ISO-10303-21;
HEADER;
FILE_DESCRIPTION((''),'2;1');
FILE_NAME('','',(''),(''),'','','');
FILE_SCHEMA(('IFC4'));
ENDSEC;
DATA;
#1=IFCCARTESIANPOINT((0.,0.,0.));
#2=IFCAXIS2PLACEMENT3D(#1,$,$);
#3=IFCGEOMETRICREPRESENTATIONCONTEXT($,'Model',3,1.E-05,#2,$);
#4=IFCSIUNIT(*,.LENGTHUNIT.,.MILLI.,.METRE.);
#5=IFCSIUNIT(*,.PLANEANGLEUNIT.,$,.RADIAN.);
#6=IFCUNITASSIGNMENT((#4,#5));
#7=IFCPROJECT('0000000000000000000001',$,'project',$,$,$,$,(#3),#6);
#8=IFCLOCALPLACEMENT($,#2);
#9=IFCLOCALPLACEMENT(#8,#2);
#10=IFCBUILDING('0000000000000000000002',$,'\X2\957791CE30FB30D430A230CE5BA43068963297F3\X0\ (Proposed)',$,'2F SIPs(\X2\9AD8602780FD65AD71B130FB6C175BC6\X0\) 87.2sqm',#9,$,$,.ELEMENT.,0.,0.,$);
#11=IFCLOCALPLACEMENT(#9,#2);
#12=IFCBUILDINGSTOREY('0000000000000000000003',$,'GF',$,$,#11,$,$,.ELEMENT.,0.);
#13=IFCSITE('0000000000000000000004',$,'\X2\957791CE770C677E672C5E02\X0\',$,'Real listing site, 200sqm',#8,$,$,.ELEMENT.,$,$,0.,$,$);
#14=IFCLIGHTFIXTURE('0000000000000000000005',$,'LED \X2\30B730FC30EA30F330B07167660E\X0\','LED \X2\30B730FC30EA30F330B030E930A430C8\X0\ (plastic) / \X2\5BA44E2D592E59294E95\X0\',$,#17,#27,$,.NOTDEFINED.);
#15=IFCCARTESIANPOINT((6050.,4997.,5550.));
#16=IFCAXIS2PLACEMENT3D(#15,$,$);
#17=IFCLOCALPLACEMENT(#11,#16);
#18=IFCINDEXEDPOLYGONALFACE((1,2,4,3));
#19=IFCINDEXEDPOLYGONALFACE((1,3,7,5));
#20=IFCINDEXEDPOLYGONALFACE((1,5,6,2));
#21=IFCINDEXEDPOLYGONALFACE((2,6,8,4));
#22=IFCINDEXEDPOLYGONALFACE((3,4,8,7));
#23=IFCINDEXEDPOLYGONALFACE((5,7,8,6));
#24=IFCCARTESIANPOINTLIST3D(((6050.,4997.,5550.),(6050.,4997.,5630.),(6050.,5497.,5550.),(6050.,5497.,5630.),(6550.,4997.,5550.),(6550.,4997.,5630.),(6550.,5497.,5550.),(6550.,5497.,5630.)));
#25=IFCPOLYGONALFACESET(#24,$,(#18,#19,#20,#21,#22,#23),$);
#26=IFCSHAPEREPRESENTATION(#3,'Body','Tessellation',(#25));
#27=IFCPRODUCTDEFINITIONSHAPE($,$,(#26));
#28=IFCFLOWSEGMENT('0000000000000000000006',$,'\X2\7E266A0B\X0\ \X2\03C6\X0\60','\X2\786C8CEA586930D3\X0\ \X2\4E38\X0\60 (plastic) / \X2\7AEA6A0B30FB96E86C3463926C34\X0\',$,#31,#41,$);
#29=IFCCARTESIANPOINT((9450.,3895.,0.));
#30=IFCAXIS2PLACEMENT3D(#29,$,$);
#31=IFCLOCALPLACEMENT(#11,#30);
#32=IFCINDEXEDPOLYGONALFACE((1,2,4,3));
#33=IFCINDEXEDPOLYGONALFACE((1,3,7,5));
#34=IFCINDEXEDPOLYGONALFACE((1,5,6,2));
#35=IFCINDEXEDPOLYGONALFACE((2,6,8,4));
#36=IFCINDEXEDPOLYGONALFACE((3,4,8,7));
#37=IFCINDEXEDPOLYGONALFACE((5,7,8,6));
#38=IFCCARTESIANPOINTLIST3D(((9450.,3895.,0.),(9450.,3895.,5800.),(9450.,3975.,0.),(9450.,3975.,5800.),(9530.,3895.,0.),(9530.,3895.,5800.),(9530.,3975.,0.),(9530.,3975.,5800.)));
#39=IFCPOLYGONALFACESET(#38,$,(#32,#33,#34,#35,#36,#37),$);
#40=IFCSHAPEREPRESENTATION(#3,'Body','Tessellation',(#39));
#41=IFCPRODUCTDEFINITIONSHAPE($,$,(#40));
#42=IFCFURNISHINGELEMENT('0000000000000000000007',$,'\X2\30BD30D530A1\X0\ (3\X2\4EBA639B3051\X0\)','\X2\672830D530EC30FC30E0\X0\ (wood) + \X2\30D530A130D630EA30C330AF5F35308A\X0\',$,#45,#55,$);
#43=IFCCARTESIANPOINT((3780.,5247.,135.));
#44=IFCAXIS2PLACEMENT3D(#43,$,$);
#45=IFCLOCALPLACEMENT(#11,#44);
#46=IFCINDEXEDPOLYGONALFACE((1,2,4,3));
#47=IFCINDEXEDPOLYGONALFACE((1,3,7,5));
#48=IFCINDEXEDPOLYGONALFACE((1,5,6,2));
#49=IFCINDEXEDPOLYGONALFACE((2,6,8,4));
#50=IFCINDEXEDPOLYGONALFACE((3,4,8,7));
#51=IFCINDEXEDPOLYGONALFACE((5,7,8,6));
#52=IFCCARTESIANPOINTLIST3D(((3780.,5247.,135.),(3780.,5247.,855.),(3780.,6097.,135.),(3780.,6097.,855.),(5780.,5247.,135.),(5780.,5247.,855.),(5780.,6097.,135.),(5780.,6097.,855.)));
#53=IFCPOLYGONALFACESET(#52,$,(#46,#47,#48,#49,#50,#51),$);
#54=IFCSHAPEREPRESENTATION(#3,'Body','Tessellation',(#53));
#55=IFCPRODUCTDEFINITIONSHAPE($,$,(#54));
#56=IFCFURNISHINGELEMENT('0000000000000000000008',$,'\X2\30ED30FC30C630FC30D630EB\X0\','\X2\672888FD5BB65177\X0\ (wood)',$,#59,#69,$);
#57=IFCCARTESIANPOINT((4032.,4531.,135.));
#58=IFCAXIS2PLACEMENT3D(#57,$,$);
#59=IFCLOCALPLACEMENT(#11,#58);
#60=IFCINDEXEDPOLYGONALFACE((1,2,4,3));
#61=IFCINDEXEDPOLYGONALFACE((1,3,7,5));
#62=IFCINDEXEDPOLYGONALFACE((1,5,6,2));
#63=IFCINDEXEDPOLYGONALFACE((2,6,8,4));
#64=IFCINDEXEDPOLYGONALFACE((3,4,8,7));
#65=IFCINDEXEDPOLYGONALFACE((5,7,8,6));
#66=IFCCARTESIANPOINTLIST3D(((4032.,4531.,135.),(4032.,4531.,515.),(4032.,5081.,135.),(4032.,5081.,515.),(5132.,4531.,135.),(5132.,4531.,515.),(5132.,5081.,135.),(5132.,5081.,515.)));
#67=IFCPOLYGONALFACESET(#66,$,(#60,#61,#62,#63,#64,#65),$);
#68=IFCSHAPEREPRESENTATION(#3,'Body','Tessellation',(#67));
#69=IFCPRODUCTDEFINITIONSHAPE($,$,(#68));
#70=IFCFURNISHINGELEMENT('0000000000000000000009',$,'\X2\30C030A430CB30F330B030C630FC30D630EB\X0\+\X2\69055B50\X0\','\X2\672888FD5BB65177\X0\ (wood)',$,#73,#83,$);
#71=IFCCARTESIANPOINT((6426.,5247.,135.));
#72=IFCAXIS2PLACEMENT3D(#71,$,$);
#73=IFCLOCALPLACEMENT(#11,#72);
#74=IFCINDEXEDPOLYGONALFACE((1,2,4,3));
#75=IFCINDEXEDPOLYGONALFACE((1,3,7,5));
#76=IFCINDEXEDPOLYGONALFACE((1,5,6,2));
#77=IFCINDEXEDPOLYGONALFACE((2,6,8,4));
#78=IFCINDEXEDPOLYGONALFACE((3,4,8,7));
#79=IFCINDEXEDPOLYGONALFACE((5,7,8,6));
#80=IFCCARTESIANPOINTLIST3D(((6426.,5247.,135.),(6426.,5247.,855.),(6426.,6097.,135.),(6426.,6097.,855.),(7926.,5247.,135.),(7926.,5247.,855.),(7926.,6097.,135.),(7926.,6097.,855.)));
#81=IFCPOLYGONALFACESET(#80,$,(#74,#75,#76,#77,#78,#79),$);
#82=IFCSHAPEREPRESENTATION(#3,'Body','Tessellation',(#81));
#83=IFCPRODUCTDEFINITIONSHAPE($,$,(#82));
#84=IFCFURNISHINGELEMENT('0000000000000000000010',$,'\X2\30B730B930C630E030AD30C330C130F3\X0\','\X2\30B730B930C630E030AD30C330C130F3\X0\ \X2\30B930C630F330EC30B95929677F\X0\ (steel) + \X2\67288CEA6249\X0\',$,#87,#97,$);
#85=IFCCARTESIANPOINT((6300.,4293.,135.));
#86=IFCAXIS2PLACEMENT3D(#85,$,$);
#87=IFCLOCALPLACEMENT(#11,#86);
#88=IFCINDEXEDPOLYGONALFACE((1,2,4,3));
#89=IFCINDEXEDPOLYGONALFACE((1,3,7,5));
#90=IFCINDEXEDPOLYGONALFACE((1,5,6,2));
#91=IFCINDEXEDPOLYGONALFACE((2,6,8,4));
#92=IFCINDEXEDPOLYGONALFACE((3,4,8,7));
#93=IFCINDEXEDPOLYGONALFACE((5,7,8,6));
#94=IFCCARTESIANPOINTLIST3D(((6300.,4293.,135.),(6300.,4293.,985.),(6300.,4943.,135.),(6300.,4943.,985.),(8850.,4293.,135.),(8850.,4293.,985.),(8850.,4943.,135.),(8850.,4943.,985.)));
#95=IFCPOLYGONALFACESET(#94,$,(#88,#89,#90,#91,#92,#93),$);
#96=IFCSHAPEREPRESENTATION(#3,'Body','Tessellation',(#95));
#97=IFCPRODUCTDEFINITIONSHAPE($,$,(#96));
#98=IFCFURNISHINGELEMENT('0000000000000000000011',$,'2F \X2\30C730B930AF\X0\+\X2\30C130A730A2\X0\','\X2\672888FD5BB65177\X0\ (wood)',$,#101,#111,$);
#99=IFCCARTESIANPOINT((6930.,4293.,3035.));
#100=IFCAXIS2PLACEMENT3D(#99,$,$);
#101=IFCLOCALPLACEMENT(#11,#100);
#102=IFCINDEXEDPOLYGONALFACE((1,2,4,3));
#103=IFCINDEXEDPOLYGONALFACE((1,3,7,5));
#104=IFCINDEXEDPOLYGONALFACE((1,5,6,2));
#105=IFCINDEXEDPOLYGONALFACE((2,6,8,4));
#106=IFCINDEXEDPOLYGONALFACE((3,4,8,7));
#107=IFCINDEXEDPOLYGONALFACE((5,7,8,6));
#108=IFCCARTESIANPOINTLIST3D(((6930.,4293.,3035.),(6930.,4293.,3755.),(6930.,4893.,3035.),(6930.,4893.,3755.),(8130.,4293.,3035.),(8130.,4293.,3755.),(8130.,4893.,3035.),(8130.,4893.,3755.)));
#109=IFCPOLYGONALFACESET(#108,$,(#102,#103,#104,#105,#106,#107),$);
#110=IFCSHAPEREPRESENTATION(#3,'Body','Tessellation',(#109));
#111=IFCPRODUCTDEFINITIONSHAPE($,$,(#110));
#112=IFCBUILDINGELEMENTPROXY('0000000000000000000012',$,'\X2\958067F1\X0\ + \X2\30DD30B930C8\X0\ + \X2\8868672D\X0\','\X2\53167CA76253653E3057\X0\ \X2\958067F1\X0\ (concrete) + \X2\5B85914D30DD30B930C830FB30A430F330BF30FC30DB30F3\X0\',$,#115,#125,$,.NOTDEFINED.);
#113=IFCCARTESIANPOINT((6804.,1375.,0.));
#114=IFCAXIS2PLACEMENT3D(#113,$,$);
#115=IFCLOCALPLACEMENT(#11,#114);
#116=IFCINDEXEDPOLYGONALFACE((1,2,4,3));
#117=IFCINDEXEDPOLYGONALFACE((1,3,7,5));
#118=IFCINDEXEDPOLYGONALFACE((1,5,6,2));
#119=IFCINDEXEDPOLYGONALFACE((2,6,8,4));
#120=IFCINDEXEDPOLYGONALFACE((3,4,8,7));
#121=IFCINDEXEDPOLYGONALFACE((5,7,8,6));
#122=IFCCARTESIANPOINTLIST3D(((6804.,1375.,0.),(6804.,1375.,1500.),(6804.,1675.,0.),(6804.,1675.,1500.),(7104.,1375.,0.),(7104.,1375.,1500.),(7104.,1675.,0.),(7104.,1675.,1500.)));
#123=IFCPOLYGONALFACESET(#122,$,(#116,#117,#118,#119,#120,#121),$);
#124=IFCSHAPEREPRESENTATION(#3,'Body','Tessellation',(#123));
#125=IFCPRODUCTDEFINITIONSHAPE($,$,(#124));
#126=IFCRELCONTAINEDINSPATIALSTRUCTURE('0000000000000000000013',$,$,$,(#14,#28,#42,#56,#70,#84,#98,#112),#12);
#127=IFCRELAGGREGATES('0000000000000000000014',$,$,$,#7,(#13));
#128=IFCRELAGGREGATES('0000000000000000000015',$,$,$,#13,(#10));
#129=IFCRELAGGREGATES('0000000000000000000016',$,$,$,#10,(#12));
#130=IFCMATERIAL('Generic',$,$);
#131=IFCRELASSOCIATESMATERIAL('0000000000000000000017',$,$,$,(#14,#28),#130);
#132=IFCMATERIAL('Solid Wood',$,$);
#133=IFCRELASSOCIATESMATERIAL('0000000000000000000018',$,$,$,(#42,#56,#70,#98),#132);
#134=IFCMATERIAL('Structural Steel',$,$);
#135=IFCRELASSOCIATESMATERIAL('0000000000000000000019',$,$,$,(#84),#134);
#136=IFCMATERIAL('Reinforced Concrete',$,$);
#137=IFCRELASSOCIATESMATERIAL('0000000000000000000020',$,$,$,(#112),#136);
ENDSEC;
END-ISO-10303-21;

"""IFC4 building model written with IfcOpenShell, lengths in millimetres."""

from ifc_helpers import new_model, si_unit, frame, frame_2d, origin, place, context, project, spatial, rectangle, extrude, material, element, save


model = new_model("IFC4")

# Units and contexts
model_context = context("Model", 3, precision=1e-05, world=origin())
ifc_project = project(units=[si_unit("LENGTHUNIT", "METRE", prefix="MILLI"), si_unit("PLANEANGLEUNIT", "RADIAN")], contexts=[model_context])

# Site, building, storey
site_placement = place(None, origin())
site = spatial("IfcSite", under=ifc_project, at=site_placement, Name="長野県松本市", ObjectType="Real listing site, 200sqm", CompositionType="ELEMENT", RefElevation=0.0)
building_placement = place(site_placement, origin())
building = spatial("IfcBuilding", under=site, at=building_placement, Name="長野・ピアノ室と防音 (Proposed)", ObjectType="2F SIPs(高性能断熱・気密) 87.2sqm", CompositionType="ELEMENT", ElevationOfRefHeight=0.0, ElevationOfTerrain=0.0)
storey_placement = place(building_placement, origin())
storey = spatial("IfcBuildingStorey", under=building, at=storey_placement, Name="GF", CompositionType="ELEMENT", Elevation=0.0)

# Shared definitions
ifc_material_1 = material(Name="Solid Wood")

# Shared definitions
ifc_material_2 = material(Name="Reinforced Concrete")

# Shared definitions
ifc_material_3 = material(Name="Structural Steel")

# Shared definitions
ifc_material_4 = material(Name="Generic")

# Light fixture
light_fixture_1_placement = place(storey_placement, frame((6050.0, 4997.0, 5550.0)))
element("IfcLightFixture", 1, at=light_fixture_1_placement, inside=storey, material=ifc_material_4, Name="LED シーリング照明", Description="LED シーリングライト (plastic) / 室中央天井", PredefinedType="NOTDEFINED", context=model_context, shape_type="SweptSolid", body=[
    extrude(rectangle(XDim=500.0, YDim=500.0, at=frame_2d((250.0, 250.0))), frame((6050.0, 4997.0, 5550.0)), (0.0, 0.0, 1.0), 80.0),
])

# Flow segment
flow_segment_placement = place(storey_placement, frame((9450.0, 3895.0, 0.0)))
element("IfcFlowSegment", 2, at=flow_segment_placement, inside=storey, material=ifc_material_4, Name="縦樋 φ60", Description="硬質塩ビ 丸60 (plastic) / 竪樋・雨水排水", context=model_context, shape_type="SweptSolid", body=[
    extrude(rectangle(XDim=80.0, YDim=80.0, at=frame_2d((40.0, 40.0))), frame((9450.0, 3895.0, 0.0)), (0.0, 0.0, 1.0), 5800.0),
])

# Furnishing elements
furnishing_1_placement = place(storey_placement, frame((3780.0, 5247.0, 135.0)))
element("IfcFurnishingElement", 3, at=furnishing_1_placement, inside=storey, material=ifc_material_1, Name="ソファ (3人掛け)", Description="木フレーム (wood) + ファブリック張り", context=model_context, shape_type="SweptSolid", body=[
    extrude(rectangle(XDim=2000.0, YDim=850.0, at=frame_2d((1000.0, 425.0))), frame((3780.0, 5247.0, 135.0)), (0.0, 0.0, 1.0), 720.0),
])
furnishing_2_placement = place(storey_placement, frame((4032.0, 4531.0, 135.0)))
element("IfcFurnishingElement", 4, at=furnishing_2_placement, inside=storey, material=ifc_material_1, Name="ローテーブル", Description="木製家具 (wood)", context=model_context, shape_type="SweptSolid", body=[
    extrude(rectangle(XDim=1100.0, YDim=550.0, at=frame_2d((550.0, 275.0))), frame((4032.0, 4531.0, 135.0)), (0.0, 0.0, 1.0), 380.0),
])
furnishing_3_placement = place(storey_placement, frame((6426.0, 5247.0, 135.0)))
element("IfcFurnishingElement", 5, at=furnishing_3_placement, inside=storey, material=ifc_material_1, Name="ダイニングテーブル+椅子", Description="木製家具 (wood)", context=model_context, shape_type="SweptSolid", body=[
    extrude(rectangle(XDim=1500.0, YDim=850.0, at=frame_2d((750.0, 425.0))), frame((6426.0, 5247.0, 135.0)), (0.0, 0.0, 1.0), 720.0),
])
furnishing_4_placement = place(storey_placement, frame((6300.0, 4293.0, 135.0)))
element("IfcFurnishingElement", 6, at=furnishing_4_placement, inside=storey, material=ifc_material_3, Name="システムキッチン", Description="システムキッチン ステンレス天板 (steel) + 木質扉", context=model_context, shape_type="SweptSolid", body=[
    extrude(rectangle(XDim=2550.0, YDim=650.0, at=frame_2d((1275.0, 325.0))), frame((6300.0, 4293.0, 135.0)), (0.0, 0.0, 1.0), 850.0),
])
furnishing_5_placement = place(storey_placement, frame((6930.0, 4293.0, 3035.0)))
element("IfcFurnishingElement", 7, at=furnishing_5_placement, inside=storey, material=ifc_material_1, Name="2F デスク+チェア", Description="木製家具 (wood)", context=model_context, shape_type="SweptSolid", body=[
    extrude(rectangle(XDim=1200.0, YDim=600.0, at=frame_2d((600.0, 300.0))), frame((6930.0, 4293.0, 3035.0)), (0.0, 0.0, 1.0), 720.0),
])

# Building element proxy
proxy_placement = place(storey_placement, frame((6804.0, 1375.0, 0.0)))
element("IfcBuildingElementProxy", 8, at=proxy_placement, inside=storey, material=ifc_material_2, Name="門柱 + ポスト + 表札", Description="化粧打放し 門柱 (concrete) + 宅配ポスト・インターホン", PredefinedType="NOTDEFINED", context=model_context, shape_type="SweptSolid", body=[
    extrude(rectangle(XDim=300.0, YDim=300.0, at=frame_2d((150.0, 150.0))), frame((6804.0, 1375.0, 0.0)), (0.0, 0.0, 1.0), 1500.0),
])

save(model, "model.ifc")
